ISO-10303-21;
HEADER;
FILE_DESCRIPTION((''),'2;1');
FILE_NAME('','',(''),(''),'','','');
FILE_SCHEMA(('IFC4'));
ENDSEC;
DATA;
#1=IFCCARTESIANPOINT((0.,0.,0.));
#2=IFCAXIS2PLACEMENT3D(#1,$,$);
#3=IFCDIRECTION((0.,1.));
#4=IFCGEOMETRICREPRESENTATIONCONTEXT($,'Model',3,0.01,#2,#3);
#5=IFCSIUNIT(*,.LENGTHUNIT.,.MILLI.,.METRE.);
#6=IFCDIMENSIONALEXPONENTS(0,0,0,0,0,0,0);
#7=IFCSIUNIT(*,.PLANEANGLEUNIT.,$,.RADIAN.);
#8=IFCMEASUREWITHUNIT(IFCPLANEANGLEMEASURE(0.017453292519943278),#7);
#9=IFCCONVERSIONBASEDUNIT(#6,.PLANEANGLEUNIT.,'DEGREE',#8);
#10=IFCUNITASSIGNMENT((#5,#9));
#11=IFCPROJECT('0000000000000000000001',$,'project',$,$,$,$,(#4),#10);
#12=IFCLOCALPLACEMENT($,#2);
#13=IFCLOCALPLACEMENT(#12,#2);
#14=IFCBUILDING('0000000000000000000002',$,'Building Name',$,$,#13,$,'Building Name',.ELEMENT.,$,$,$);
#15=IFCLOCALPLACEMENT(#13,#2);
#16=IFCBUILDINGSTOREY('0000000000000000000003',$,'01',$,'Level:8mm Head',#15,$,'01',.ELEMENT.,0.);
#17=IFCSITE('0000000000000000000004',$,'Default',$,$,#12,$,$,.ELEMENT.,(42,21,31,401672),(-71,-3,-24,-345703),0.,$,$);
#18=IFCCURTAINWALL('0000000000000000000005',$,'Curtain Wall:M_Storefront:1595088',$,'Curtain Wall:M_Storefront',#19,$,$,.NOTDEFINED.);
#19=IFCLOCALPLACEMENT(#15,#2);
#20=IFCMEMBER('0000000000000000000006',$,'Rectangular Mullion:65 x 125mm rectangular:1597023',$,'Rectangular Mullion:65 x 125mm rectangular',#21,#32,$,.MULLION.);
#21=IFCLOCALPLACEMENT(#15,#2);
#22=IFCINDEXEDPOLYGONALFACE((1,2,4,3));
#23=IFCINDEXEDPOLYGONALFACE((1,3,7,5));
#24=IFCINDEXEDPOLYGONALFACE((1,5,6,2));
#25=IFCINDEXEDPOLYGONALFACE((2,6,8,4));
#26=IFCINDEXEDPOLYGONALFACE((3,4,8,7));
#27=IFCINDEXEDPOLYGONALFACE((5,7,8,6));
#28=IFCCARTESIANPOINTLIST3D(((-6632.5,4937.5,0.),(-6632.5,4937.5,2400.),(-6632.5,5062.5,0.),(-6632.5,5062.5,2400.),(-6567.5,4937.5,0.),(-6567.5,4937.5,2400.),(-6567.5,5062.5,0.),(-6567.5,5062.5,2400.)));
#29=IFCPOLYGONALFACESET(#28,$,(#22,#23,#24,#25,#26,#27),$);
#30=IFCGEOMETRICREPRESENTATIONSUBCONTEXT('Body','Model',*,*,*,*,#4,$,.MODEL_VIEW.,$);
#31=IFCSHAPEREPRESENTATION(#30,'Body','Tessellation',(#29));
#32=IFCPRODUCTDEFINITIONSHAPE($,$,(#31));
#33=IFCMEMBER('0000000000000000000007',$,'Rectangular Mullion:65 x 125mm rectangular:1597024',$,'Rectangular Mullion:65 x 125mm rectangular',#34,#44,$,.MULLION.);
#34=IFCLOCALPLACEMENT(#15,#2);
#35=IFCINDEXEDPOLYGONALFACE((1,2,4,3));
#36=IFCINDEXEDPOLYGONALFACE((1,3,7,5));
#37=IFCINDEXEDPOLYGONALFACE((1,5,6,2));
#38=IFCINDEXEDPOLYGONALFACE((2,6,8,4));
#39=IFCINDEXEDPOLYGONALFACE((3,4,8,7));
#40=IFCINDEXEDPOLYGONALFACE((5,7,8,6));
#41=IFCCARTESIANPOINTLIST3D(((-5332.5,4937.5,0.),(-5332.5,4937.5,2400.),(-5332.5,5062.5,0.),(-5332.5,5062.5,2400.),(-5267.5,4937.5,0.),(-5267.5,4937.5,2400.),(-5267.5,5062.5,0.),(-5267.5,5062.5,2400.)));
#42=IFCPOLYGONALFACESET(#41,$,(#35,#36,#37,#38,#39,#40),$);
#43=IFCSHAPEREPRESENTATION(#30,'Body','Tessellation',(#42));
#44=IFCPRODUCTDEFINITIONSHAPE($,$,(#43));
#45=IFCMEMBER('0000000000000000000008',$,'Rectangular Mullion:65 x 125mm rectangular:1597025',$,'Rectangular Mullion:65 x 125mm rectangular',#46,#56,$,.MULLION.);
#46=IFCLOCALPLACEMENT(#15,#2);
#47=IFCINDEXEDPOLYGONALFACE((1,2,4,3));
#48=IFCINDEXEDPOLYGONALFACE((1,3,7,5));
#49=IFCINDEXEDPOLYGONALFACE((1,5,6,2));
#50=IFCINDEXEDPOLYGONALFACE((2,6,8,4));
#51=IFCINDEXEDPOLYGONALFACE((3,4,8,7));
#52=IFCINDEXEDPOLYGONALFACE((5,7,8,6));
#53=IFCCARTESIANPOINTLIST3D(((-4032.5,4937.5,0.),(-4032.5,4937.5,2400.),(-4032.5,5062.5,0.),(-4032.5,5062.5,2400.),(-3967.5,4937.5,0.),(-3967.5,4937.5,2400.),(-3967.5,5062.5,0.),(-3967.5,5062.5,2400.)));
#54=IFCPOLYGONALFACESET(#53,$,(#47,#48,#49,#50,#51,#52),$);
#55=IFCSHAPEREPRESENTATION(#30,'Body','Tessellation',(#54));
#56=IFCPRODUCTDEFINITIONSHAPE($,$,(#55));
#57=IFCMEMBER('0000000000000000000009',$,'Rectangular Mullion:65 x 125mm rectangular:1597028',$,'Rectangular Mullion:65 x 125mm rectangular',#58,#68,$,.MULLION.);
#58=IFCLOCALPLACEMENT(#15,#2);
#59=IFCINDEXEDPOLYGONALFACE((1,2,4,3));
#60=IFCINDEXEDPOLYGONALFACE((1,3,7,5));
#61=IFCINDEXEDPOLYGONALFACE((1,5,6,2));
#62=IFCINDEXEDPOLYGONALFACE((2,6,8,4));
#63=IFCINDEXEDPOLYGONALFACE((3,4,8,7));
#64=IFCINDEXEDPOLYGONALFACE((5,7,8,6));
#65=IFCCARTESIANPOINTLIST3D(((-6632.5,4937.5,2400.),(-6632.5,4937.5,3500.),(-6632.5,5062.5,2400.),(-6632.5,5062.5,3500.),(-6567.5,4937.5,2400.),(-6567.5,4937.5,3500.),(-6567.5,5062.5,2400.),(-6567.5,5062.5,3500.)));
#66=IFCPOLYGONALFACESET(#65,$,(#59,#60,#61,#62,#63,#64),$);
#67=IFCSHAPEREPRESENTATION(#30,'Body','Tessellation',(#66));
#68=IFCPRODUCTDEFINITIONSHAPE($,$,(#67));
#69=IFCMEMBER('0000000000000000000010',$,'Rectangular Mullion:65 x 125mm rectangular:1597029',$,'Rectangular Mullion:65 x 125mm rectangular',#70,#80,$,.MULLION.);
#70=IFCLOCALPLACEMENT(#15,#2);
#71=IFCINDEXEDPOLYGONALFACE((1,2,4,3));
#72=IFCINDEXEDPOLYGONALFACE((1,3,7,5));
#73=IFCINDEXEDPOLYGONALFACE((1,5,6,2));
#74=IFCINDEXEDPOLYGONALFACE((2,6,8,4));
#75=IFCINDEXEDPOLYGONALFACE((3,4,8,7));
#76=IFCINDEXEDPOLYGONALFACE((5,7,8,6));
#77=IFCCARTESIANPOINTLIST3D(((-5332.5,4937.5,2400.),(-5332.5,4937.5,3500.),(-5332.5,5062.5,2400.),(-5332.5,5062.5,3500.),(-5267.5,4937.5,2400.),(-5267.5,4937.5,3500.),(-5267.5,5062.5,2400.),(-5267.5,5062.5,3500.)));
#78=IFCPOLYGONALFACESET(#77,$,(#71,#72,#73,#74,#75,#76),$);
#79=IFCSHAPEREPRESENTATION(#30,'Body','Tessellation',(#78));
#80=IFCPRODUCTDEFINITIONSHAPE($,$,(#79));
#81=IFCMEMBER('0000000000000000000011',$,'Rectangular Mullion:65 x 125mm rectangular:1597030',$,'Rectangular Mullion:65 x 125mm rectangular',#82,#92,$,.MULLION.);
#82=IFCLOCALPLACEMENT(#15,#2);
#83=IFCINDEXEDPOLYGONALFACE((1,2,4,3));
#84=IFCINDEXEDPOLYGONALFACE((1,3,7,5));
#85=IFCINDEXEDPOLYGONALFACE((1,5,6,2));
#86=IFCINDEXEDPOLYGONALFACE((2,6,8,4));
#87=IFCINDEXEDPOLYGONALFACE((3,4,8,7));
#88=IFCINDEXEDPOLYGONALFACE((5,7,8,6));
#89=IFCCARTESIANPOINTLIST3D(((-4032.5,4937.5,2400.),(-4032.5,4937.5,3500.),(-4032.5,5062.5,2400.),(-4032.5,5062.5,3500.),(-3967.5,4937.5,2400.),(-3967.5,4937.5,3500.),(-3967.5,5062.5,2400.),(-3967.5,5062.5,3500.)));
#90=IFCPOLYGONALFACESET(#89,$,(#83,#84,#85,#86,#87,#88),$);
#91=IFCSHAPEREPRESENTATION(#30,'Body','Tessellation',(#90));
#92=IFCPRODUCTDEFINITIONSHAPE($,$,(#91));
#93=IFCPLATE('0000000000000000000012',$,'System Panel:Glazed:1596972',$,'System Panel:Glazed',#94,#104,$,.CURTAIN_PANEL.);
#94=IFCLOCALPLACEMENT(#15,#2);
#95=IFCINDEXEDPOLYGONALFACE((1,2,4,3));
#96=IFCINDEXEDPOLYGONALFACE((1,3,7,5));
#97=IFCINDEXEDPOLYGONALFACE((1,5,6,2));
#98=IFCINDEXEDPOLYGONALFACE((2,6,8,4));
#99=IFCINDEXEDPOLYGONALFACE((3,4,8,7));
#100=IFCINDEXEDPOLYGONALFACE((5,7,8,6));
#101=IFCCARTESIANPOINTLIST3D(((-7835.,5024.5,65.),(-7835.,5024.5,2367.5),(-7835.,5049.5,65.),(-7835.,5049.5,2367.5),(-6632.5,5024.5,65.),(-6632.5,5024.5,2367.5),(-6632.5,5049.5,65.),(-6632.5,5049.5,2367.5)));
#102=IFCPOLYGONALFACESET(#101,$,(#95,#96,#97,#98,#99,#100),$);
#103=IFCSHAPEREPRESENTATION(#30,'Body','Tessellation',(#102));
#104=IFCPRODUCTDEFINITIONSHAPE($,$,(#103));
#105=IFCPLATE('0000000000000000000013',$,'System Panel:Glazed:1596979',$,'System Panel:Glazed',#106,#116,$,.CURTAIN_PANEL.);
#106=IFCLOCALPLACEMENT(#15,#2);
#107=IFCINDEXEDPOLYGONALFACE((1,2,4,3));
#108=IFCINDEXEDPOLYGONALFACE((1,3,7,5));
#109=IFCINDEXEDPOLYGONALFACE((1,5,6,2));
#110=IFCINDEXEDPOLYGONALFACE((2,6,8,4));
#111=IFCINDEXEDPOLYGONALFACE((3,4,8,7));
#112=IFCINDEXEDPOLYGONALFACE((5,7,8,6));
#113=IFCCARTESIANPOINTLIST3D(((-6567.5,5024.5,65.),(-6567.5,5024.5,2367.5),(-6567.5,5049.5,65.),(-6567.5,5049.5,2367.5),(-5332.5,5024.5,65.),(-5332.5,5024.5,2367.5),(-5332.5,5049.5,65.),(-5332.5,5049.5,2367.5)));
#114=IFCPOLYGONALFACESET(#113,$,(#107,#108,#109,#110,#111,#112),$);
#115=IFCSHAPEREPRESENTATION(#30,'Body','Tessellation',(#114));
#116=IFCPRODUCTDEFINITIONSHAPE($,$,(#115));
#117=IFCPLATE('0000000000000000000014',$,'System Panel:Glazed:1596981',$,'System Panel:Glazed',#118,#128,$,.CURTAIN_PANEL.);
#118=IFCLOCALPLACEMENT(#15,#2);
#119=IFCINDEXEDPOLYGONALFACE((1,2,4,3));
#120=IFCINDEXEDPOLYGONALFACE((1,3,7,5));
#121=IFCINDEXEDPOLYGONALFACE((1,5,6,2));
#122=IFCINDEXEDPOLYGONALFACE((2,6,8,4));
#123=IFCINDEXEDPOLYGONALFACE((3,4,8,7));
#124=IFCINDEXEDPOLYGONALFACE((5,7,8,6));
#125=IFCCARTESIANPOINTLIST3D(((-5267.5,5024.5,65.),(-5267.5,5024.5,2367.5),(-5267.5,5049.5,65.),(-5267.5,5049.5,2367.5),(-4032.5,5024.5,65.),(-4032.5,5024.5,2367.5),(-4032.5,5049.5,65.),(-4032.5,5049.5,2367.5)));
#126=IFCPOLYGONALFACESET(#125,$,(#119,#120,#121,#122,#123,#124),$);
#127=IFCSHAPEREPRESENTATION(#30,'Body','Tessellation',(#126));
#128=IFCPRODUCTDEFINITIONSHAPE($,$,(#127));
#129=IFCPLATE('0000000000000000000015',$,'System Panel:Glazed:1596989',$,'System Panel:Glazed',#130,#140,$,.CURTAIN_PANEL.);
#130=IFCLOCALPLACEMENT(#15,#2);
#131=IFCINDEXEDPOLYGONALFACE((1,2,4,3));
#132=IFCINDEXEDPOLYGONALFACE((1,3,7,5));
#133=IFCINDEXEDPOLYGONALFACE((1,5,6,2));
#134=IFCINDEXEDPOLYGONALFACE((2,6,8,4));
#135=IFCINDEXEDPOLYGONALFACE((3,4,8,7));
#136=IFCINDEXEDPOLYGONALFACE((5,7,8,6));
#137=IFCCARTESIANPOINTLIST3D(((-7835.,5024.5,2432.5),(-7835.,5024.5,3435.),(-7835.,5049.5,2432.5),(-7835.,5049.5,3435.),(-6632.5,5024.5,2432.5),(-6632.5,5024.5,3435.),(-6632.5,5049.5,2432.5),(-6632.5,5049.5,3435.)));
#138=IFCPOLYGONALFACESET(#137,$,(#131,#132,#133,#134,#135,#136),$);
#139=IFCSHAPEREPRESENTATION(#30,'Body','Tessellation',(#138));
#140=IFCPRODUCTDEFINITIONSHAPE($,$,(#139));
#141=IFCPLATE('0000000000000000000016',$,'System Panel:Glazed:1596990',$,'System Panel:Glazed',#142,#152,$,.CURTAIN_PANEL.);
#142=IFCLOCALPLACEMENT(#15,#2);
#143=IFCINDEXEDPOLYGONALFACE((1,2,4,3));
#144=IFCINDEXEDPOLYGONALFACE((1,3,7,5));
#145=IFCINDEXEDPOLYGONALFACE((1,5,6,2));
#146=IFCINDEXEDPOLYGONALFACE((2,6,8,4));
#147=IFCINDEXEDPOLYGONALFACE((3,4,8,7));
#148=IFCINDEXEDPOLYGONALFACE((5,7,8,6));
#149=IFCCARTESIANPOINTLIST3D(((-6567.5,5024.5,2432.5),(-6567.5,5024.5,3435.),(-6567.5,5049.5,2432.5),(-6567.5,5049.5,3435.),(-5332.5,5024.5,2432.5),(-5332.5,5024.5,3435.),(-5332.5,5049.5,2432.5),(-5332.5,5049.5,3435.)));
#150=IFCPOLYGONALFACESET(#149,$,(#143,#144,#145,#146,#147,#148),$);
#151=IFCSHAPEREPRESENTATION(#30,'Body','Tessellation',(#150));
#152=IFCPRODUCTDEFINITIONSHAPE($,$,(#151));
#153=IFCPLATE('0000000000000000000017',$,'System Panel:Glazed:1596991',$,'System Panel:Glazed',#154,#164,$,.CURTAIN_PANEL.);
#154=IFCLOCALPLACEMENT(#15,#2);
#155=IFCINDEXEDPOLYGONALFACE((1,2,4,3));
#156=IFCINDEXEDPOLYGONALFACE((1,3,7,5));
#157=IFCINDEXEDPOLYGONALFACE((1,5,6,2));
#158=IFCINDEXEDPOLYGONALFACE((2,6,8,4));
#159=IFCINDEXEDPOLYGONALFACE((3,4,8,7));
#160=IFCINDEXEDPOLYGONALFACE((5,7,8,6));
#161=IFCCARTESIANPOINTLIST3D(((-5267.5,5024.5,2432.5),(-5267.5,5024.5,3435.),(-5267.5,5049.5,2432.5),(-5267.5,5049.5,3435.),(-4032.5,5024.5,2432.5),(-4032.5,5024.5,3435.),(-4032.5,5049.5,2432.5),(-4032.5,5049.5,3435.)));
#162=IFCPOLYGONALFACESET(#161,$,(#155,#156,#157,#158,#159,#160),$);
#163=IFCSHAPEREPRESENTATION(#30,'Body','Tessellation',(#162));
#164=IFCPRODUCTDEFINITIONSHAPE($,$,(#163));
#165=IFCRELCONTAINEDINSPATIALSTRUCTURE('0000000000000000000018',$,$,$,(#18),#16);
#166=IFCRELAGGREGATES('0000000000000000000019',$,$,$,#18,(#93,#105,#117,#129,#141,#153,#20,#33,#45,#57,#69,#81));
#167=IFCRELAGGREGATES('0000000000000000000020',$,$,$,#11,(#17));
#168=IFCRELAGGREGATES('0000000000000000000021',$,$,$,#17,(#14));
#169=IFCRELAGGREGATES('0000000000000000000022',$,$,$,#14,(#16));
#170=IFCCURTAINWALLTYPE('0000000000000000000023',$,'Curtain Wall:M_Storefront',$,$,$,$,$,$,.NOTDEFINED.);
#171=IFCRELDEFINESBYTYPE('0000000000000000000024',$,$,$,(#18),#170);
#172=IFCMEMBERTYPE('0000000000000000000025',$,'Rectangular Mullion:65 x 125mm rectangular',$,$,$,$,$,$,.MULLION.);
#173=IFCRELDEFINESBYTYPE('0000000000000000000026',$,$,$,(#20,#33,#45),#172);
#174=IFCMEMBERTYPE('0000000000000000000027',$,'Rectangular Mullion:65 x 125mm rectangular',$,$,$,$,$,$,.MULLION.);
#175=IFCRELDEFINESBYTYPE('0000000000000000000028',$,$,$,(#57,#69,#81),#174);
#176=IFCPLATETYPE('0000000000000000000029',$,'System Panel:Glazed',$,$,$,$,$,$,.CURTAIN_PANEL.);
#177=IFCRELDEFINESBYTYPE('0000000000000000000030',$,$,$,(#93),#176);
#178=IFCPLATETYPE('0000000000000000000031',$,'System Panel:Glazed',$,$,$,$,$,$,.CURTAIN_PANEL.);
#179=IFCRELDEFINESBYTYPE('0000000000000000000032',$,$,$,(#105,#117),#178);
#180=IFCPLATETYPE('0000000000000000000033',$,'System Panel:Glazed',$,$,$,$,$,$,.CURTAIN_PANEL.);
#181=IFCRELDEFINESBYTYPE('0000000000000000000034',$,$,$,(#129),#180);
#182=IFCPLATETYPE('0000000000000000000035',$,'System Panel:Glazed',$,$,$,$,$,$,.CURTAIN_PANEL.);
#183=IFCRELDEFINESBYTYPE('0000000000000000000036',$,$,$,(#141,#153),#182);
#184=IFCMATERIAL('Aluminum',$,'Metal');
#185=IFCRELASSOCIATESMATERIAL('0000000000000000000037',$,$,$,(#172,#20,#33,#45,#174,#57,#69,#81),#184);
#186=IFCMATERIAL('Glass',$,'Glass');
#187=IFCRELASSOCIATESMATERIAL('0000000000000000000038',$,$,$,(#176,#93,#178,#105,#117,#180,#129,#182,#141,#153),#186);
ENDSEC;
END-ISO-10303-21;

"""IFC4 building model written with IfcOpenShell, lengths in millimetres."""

from ifc_helpers import new_model, entity, si_unit, converted_unit, direction, frame, origin, place, context, subcontext, project, spatial, indexed_curve, outline, extrude, source, transform, mapped, material, type_object, type_shapes, element, aggregate, save


model = new_model("IFC4")

# Units and contexts
model_context = context("Model", 3, precision=0.01, world=origin(), true_north=direction((0.0, 1.0)))
body_context = subcontext(model_context, "Body", "Model", "MODEL_VIEW")
ifc_project = project(units=[si_unit("LENGTHUNIT", "METRE", prefix="MILLI"), converted_unit("PLANEANGLEUNIT", "DEGREE", entity("IfcPlaneAngleMeasure", 0.017453292519943278), si_unit("PLANEANGLEUNIT", "RADIAN"), dimensions=[0, 0, 0, 0, 0, 0, 0])], contexts=[model_context])

# Site, building, storey
site_placement = place(None, origin())
site = spatial("IfcSite", under=ifc_project, at=site_placement, Name="Default", CompositionType="ELEMENT", RefLatitude=(42, 21, 31, 401672), RefLongitude=(-71, -3, -24, -345703), RefElevation=0.0)
building_placement = place(site_placement, origin())
building = spatial("IfcBuilding", under=site, at=building_placement, Name="Building Name", LongName="Building Name", CompositionType="ELEMENT")
storey_placement = place(building_placement, origin())
storey = spatial("IfcBuildingStorey", under=building, at=storey_placement, Name="01", ObjectType="Level:8mm Head", LongName="01", CompositionType="ELEMENT", Elevation=0.0)

# Curtain wall, members, plates
curtain_wall_type = type_object("IfcCurtainWallType", Name="Curtain Wall:M_Storefront", PredefinedType="NOTDEFINED")
curtain_wall_placement = place(storey_placement, origin())
curtain_wall = element("IfcCurtainWall", 1, at=curtain_wall_placement, inside=storey, type_object=curtain_wall_type, Name="Curtain Wall:M_Storefront:1595088", ObjectType="Curtain Wall:M_Storefront", PredefinedType="NOTDEFINED")
ifc_material_1 = material(Name="Aluminum", Category="Metal")
member_type_1 = type_object("IfcMemberType", Name="Rectangular Mullion:65 x 125mm rectangular", PredefinedType="MULLION", material=ifc_material_1)
shared_shape_1 = source(origin(), body_context, "Body", "SweptSolid", [
    extrude(outline(indexed_curve([(-32.5, -62.5), (32.5, -62.5), (32.5, 62.5), (-32.5, 62.5), (-32.5, -62.5)], self_intersect=False)), frame((0.0, 0.0, -2400.0), z_axis=(0.0, 0.0, 1.0), x_axis=(-1.0, 0.0, 0.0)), (0.0, 0.0, 1.0), 2400.0),
])
type_shapes(member_type_1, [shared_shape_1])
member_1_placement = place(curtain_wall_placement, frame((-6600.0, 5000.0, 0.0), z_axis=(0.0, 0.0, -1.0), x_axis=(1.0, 0.0, 0.0)))
member_1 = element("IfcMember", 2, at=member_1_placement, type_object=member_type_1, material=ifc_material_1, Name="Rectangular Mullion:65 x 125mm rectangular:1597023", ObjectType="Rectangular Mullion:65 x 125mm rectangular", PredefinedType="MULLION", context=body_context, shape_type="MappedRepresentation", body=[
    mapped(shared_shape_1, transform((0.0, 0.0, 0.0), scale=1.0)),
])
member_2_placement = place(curtain_wall_placement, frame((-5300.0, 5000.0, 0.0), z_axis=(0.0, 0.0, -1.0), x_axis=(1.0, 0.0, 0.0)))
member_2 = element("IfcMember", 3, at=member_2_placement, type_object=member_type_1, material=ifc_material_1, Name="Rectangular Mullion:65 x 125mm rectangular:1597024", ObjectType="Rectangular Mullion:65 x 125mm rectangular", PredefinedType="MULLION", context=body_context, shape_type="MappedRepresentation", body=[
    mapped(shared_shape_1, transform((0.0, 0.0, 0.0), scale=1.0)),
])
member_3_placement = place(curtain_wall_placement, frame((-4000.0, 5000.0, 0.0), z_axis=(0.0, 0.0, -1.0), x_axis=(1.0, 0.0, 0.0)))
member_3 = element("IfcMember", 4, at=member_3_placement, type_object=member_type_1, material=ifc_material_1, Name="Rectangular Mullion:65 x 125mm rectangular:1597025", ObjectType="Rectangular Mullion:65 x 125mm rectangular", PredefinedType="MULLION", context=body_context, shape_type="MappedRepresentation", body=[
    mapped(shared_shape_1, transform((0.0, 0.0, 0.0), scale=1.0)),
])
member_type_2 = type_object("IfcMemberType", Name="Rectangular Mullion:65 x 125mm rectangular", PredefinedType="MULLION", material=ifc_material_1)
shared_shape_2 = source(origin(), body_context, "Body", "SweptSolid", [
    extrude(outline(indexed_curve([(-32.5, -62.5), (32.5, -62.5), (32.5, 62.5), (-32.5, 62.5), (-32.5, -62.5)], self_intersect=False)), frame((0.0, 0.0, -1100.0), z_axis=(0.0, 0.0, 1.0), x_axis=(-1.0, 0.0, 0.0)), (0.0, 0.0, 1.0), 1100.0),
])
type_shapes(member_type_2, [shared_shape_2])
member_4_placement = place(curtain_wall_placement, frame((-6600.0, 5000.0, 2400.0), z_axis=(0.0, 0.0, -1.0), x_axis=(1.0, 0.0, 0.0)))
member_4 = element("IfcMember", 5, at=member_4_placement, type_object=member_type_2, material=ifc_material_1, Name="Rectangular Mullion:65 x 125mm rectangular:1597028", ObjectType="Rectangular Mullion:65 x 125mm rectangular", PredefinedType="MULLION", context=body_context, shape_type="MappedRepresentation", body=[
    mapped(shared_shape_2, transform((0.0, 0.0, 0.0), scale=1.0)),
])
member_5_placement = place(curtain_wall_placement, frame((-5300.0, 5000.0, 2400.0), z_axis=(0.0, 0.0, -1.0), x_axis=(1.0, 0.0, 0.0)))
member_5 = element("IfcMember", 6, at=member_5_placement, type_object=member_type_2, material=ifc_material_1, Name="Rectangular Mullion:65 x 125mm rectangular:1597029", ObjectType="Rectangular Mullion:65 x 125mm rectangular", PredefinedType="MULLION", context=body_context, shape_type="MappedRepresentation", body=[
    mapped(shared_shape_2, transform((0.0, 0.0, 0.0), scale=1.0)),
])
member_6_placement = place(curtain_wall_placement, frame((-4000.0, 5000.0, 2400.0), z_axis=(0.0, 0.0, -1.0), x_axis=(1.0, 0.0, 0.0)))
member_6 = element("IfcMember", 7, at=member_6_placement, type_object=member_type_2, material=ifc_material_1, Name="Rectangular Mullion:65 x 125mm rectangular:1597030", ObjectType="Rectangular Mullion:65 x 125mm rectangular", PredefinedType="MULLION", context=body_context, shape_type="MappedRepresentation", body=[
    mapped(shared_shape_2, transform((0.0, 0.0, 0.0), scale=1.0)),
])
ifc_material_2 = material(Name="Glass", Category="Glass")
plate_type_1 = type_object("IfcPlateType", Name="System Panel:Glazed", PredefinedType="CURTAIN_PANEL", material=ifc_material_2)
shared_shape_3 = source(origin(), body_context, "Body", "SweptSolid", [
    extrude(outline(indexed_curve([(-12.5, -601.3), (12.5, -601.3), (12.5, 601.3), (-12.5, 601.3), (-12.5, -601.3)], self_intersect=False)), frame((0.0, 37.0, 0.0), z_axis=(0.0, 0.0, 1.0), x_axis=(0.0, 1.0, 0.0)), (0.0, 0.0, 1.0), 2302.5),
])
type_shapes(plate_type_1, [shared_shape_3])
plate_1_placement = place(curtain_wall_placement, frame((-7233.7, 5000.0, 65.0)))
plate_1 = element("IfcPlate", 8, at=plate_1_placement, type_object=plate_type_1, material=ifc_material_2, Name="System Panel:Glazed:1596972", ObjectType="System Panel:Glazed", PredefinedType="CURTAIN_PANEL", context=body_context, shape_type="MappedRepresentation", body=[
    mapped(shared_shape_3, transform((0.0, 0.0, 0.0), scale=1.0)),
])
plate_type_2 = type_object("IfcPlateType", Name="System Panel:Glazed", PredefinedType="CURTAIN_PANEL", material=ifc_material_2)
shared_shape_4 = source(origin(), body_context, "Body", "SweptSolid", [
    extrude(outline(indexed_curve([(-12.5, -617.5), (12.5, -617.5), (12.5, 617.5), (-12.5, 617.5), (-12.5, -617.5)], self_intersect=False)), frame((0.0, 37.0, 0.0), z_axis=(0.0, 0.0, 1.0), x_axis=(0.0, 1.0, 0.0)), (0.0, 0.0, 1.0), 2302.5),
])
type_shapes(plate_type_2, [shared_shape_4])
plate_2_placement = place(curtain_wall_placement, frame((-5950.0, 5000.0, 65.0)))
plate_2 = element("IfcPlate", 9, at=plate_2_placement, type_object=plate_type_2, material=ifc_material_2, Name="System Panel:Glazed:1596979", ObjectType="System Panel:Glazed", PredefinedType="CURTAIN_PANEL", context=body_context, shape_type="MappedRepresentation", body=[
    mapped(shared_shape_4, transform((0.0, 0.0, 0.0), scale=1.0)),
])
plate_3_placement = place(curtain_wall_placement, frame((-4650.0, 5000.0, 65.0)))
plate_3 = element("IfcPlate", 10, at=plate_3_placement, type_object=plate_type_2, material=ifc_material_2, Name="System Panel:Glazed:1596981", ObjectType="System Panel:Glazed", PredefinedType="CURTAIN_PANEL", context=body_context, shape_type="MappedRepresentation", body=[
    mapped(shared_shape_4, transform((0.0, 0.0, 0.0), scale=1.0)),
])
plate_type_3 = type_object("IfcPlateType", Name="System Panel:Glazed", PredefinedType="CURTAIN_PANEL", material=ifc_material_2)
shared_shape_5 = source(origin(), body_context, "Body", "SweptSolid", [
    extrude(outline(indexed_curve([(-12.5, -601.3), (12.5, -601.3), (12.5, 601.3), (-12.5, 601.3), (-12.5, -601.3)], self_intersect=False)), frame((0.0, 37.0, 0.0), z_axis=(0.0, 0.0, 1.0), x_axis=(0.0, 1.0, 0.0)), (0.0, 0.0, 1.0), 1002.5),
])
type_shapes(plate_type_3, [shared_shape_5])
plate_4_placement = place(curtain_wall_placement, frame((-7233.7, 5000.0, 2432.5)))
plate_4 = element("IfcPlate", 11, at=plate_4_placement, type_object=plate_type_3, material=ifc_material_2, Name="System Panel:Glazed:1596989", ObjectType="System Panel:Glazed", PredefinedType="CURTAIN_PANEL", context=body_context, shape_type="MappedRepresentation", body=[
    mapped(shared_shape_5, transform((0.0, 0.0, 0.0), scale=1.0)),
])
plate_type_4 = type_object("IfcPlateType", Name="System Panel:Glazed", PredefinedType="CURTAIN_PANEL", material=ifc_material_2)
shared_shape_6 = source(origin(), body_context, "Body", "SweptSolid", [
    extrude(outline(indexed_curve([(-12.5, -617.5), (12.5, -617.5), (12.5, 617.5), (-12.5, 617.5), (-12.5, -617.5)], self_intersect=False)), frame((0.0, 37.0, 0.0), z_axis=(0.0, 0.0, 1.0), x_axis=(0.0, 1.0, 0.0)), (0.0, 0.0, 1.0), 1002.5),
])
type_shapes(plate_type_4, [shared_shape_6])
plate_5_placement = place(curtain_wall_placement, frame((-5950.0, 5000.0, 2432.5)))
plate_5 = element("IfcPlate", 12, at=plate_5_placement, type_object=plate_type_4, material=ifc_material_2, Name="System Panel:Glazed:1596990", ObjectType="System Panel:Glazed", PredefinedType="CURTAIN_PANEL", context=body_context, shape_type="MappedRepresentation", body=[
    mapped(shared_shape_6, transform((0.0, 0.0, 0.0), scale=1.0)),
])
plate_6_placement = place(curtain_wall_placement, frame((-4650.0, 5000.0, 2432.5)))
plate_6 = element("IfcPlate", 13, at=plate_6_placement, type_object=plate_type_4, material=ifc_material_2, Name="System Panel:Glazed:1596991", ObjectType="System Panel:Glazed", PredefinedType="CURTAIN_PANEL", context=body_context, shape_type="MappedRepresentation", body=[
    mapped(shared_shape_6, transform((0.0, 0.0, 0.0), scale=1.0)),
])
aggregate(curtain_wall, [plate_1, plate_2, plate_3, plate_4, plate_5, plate_6, member_1, member_2, member_3, member_4, member_5, member_6])

save(model, "model.ifc")
